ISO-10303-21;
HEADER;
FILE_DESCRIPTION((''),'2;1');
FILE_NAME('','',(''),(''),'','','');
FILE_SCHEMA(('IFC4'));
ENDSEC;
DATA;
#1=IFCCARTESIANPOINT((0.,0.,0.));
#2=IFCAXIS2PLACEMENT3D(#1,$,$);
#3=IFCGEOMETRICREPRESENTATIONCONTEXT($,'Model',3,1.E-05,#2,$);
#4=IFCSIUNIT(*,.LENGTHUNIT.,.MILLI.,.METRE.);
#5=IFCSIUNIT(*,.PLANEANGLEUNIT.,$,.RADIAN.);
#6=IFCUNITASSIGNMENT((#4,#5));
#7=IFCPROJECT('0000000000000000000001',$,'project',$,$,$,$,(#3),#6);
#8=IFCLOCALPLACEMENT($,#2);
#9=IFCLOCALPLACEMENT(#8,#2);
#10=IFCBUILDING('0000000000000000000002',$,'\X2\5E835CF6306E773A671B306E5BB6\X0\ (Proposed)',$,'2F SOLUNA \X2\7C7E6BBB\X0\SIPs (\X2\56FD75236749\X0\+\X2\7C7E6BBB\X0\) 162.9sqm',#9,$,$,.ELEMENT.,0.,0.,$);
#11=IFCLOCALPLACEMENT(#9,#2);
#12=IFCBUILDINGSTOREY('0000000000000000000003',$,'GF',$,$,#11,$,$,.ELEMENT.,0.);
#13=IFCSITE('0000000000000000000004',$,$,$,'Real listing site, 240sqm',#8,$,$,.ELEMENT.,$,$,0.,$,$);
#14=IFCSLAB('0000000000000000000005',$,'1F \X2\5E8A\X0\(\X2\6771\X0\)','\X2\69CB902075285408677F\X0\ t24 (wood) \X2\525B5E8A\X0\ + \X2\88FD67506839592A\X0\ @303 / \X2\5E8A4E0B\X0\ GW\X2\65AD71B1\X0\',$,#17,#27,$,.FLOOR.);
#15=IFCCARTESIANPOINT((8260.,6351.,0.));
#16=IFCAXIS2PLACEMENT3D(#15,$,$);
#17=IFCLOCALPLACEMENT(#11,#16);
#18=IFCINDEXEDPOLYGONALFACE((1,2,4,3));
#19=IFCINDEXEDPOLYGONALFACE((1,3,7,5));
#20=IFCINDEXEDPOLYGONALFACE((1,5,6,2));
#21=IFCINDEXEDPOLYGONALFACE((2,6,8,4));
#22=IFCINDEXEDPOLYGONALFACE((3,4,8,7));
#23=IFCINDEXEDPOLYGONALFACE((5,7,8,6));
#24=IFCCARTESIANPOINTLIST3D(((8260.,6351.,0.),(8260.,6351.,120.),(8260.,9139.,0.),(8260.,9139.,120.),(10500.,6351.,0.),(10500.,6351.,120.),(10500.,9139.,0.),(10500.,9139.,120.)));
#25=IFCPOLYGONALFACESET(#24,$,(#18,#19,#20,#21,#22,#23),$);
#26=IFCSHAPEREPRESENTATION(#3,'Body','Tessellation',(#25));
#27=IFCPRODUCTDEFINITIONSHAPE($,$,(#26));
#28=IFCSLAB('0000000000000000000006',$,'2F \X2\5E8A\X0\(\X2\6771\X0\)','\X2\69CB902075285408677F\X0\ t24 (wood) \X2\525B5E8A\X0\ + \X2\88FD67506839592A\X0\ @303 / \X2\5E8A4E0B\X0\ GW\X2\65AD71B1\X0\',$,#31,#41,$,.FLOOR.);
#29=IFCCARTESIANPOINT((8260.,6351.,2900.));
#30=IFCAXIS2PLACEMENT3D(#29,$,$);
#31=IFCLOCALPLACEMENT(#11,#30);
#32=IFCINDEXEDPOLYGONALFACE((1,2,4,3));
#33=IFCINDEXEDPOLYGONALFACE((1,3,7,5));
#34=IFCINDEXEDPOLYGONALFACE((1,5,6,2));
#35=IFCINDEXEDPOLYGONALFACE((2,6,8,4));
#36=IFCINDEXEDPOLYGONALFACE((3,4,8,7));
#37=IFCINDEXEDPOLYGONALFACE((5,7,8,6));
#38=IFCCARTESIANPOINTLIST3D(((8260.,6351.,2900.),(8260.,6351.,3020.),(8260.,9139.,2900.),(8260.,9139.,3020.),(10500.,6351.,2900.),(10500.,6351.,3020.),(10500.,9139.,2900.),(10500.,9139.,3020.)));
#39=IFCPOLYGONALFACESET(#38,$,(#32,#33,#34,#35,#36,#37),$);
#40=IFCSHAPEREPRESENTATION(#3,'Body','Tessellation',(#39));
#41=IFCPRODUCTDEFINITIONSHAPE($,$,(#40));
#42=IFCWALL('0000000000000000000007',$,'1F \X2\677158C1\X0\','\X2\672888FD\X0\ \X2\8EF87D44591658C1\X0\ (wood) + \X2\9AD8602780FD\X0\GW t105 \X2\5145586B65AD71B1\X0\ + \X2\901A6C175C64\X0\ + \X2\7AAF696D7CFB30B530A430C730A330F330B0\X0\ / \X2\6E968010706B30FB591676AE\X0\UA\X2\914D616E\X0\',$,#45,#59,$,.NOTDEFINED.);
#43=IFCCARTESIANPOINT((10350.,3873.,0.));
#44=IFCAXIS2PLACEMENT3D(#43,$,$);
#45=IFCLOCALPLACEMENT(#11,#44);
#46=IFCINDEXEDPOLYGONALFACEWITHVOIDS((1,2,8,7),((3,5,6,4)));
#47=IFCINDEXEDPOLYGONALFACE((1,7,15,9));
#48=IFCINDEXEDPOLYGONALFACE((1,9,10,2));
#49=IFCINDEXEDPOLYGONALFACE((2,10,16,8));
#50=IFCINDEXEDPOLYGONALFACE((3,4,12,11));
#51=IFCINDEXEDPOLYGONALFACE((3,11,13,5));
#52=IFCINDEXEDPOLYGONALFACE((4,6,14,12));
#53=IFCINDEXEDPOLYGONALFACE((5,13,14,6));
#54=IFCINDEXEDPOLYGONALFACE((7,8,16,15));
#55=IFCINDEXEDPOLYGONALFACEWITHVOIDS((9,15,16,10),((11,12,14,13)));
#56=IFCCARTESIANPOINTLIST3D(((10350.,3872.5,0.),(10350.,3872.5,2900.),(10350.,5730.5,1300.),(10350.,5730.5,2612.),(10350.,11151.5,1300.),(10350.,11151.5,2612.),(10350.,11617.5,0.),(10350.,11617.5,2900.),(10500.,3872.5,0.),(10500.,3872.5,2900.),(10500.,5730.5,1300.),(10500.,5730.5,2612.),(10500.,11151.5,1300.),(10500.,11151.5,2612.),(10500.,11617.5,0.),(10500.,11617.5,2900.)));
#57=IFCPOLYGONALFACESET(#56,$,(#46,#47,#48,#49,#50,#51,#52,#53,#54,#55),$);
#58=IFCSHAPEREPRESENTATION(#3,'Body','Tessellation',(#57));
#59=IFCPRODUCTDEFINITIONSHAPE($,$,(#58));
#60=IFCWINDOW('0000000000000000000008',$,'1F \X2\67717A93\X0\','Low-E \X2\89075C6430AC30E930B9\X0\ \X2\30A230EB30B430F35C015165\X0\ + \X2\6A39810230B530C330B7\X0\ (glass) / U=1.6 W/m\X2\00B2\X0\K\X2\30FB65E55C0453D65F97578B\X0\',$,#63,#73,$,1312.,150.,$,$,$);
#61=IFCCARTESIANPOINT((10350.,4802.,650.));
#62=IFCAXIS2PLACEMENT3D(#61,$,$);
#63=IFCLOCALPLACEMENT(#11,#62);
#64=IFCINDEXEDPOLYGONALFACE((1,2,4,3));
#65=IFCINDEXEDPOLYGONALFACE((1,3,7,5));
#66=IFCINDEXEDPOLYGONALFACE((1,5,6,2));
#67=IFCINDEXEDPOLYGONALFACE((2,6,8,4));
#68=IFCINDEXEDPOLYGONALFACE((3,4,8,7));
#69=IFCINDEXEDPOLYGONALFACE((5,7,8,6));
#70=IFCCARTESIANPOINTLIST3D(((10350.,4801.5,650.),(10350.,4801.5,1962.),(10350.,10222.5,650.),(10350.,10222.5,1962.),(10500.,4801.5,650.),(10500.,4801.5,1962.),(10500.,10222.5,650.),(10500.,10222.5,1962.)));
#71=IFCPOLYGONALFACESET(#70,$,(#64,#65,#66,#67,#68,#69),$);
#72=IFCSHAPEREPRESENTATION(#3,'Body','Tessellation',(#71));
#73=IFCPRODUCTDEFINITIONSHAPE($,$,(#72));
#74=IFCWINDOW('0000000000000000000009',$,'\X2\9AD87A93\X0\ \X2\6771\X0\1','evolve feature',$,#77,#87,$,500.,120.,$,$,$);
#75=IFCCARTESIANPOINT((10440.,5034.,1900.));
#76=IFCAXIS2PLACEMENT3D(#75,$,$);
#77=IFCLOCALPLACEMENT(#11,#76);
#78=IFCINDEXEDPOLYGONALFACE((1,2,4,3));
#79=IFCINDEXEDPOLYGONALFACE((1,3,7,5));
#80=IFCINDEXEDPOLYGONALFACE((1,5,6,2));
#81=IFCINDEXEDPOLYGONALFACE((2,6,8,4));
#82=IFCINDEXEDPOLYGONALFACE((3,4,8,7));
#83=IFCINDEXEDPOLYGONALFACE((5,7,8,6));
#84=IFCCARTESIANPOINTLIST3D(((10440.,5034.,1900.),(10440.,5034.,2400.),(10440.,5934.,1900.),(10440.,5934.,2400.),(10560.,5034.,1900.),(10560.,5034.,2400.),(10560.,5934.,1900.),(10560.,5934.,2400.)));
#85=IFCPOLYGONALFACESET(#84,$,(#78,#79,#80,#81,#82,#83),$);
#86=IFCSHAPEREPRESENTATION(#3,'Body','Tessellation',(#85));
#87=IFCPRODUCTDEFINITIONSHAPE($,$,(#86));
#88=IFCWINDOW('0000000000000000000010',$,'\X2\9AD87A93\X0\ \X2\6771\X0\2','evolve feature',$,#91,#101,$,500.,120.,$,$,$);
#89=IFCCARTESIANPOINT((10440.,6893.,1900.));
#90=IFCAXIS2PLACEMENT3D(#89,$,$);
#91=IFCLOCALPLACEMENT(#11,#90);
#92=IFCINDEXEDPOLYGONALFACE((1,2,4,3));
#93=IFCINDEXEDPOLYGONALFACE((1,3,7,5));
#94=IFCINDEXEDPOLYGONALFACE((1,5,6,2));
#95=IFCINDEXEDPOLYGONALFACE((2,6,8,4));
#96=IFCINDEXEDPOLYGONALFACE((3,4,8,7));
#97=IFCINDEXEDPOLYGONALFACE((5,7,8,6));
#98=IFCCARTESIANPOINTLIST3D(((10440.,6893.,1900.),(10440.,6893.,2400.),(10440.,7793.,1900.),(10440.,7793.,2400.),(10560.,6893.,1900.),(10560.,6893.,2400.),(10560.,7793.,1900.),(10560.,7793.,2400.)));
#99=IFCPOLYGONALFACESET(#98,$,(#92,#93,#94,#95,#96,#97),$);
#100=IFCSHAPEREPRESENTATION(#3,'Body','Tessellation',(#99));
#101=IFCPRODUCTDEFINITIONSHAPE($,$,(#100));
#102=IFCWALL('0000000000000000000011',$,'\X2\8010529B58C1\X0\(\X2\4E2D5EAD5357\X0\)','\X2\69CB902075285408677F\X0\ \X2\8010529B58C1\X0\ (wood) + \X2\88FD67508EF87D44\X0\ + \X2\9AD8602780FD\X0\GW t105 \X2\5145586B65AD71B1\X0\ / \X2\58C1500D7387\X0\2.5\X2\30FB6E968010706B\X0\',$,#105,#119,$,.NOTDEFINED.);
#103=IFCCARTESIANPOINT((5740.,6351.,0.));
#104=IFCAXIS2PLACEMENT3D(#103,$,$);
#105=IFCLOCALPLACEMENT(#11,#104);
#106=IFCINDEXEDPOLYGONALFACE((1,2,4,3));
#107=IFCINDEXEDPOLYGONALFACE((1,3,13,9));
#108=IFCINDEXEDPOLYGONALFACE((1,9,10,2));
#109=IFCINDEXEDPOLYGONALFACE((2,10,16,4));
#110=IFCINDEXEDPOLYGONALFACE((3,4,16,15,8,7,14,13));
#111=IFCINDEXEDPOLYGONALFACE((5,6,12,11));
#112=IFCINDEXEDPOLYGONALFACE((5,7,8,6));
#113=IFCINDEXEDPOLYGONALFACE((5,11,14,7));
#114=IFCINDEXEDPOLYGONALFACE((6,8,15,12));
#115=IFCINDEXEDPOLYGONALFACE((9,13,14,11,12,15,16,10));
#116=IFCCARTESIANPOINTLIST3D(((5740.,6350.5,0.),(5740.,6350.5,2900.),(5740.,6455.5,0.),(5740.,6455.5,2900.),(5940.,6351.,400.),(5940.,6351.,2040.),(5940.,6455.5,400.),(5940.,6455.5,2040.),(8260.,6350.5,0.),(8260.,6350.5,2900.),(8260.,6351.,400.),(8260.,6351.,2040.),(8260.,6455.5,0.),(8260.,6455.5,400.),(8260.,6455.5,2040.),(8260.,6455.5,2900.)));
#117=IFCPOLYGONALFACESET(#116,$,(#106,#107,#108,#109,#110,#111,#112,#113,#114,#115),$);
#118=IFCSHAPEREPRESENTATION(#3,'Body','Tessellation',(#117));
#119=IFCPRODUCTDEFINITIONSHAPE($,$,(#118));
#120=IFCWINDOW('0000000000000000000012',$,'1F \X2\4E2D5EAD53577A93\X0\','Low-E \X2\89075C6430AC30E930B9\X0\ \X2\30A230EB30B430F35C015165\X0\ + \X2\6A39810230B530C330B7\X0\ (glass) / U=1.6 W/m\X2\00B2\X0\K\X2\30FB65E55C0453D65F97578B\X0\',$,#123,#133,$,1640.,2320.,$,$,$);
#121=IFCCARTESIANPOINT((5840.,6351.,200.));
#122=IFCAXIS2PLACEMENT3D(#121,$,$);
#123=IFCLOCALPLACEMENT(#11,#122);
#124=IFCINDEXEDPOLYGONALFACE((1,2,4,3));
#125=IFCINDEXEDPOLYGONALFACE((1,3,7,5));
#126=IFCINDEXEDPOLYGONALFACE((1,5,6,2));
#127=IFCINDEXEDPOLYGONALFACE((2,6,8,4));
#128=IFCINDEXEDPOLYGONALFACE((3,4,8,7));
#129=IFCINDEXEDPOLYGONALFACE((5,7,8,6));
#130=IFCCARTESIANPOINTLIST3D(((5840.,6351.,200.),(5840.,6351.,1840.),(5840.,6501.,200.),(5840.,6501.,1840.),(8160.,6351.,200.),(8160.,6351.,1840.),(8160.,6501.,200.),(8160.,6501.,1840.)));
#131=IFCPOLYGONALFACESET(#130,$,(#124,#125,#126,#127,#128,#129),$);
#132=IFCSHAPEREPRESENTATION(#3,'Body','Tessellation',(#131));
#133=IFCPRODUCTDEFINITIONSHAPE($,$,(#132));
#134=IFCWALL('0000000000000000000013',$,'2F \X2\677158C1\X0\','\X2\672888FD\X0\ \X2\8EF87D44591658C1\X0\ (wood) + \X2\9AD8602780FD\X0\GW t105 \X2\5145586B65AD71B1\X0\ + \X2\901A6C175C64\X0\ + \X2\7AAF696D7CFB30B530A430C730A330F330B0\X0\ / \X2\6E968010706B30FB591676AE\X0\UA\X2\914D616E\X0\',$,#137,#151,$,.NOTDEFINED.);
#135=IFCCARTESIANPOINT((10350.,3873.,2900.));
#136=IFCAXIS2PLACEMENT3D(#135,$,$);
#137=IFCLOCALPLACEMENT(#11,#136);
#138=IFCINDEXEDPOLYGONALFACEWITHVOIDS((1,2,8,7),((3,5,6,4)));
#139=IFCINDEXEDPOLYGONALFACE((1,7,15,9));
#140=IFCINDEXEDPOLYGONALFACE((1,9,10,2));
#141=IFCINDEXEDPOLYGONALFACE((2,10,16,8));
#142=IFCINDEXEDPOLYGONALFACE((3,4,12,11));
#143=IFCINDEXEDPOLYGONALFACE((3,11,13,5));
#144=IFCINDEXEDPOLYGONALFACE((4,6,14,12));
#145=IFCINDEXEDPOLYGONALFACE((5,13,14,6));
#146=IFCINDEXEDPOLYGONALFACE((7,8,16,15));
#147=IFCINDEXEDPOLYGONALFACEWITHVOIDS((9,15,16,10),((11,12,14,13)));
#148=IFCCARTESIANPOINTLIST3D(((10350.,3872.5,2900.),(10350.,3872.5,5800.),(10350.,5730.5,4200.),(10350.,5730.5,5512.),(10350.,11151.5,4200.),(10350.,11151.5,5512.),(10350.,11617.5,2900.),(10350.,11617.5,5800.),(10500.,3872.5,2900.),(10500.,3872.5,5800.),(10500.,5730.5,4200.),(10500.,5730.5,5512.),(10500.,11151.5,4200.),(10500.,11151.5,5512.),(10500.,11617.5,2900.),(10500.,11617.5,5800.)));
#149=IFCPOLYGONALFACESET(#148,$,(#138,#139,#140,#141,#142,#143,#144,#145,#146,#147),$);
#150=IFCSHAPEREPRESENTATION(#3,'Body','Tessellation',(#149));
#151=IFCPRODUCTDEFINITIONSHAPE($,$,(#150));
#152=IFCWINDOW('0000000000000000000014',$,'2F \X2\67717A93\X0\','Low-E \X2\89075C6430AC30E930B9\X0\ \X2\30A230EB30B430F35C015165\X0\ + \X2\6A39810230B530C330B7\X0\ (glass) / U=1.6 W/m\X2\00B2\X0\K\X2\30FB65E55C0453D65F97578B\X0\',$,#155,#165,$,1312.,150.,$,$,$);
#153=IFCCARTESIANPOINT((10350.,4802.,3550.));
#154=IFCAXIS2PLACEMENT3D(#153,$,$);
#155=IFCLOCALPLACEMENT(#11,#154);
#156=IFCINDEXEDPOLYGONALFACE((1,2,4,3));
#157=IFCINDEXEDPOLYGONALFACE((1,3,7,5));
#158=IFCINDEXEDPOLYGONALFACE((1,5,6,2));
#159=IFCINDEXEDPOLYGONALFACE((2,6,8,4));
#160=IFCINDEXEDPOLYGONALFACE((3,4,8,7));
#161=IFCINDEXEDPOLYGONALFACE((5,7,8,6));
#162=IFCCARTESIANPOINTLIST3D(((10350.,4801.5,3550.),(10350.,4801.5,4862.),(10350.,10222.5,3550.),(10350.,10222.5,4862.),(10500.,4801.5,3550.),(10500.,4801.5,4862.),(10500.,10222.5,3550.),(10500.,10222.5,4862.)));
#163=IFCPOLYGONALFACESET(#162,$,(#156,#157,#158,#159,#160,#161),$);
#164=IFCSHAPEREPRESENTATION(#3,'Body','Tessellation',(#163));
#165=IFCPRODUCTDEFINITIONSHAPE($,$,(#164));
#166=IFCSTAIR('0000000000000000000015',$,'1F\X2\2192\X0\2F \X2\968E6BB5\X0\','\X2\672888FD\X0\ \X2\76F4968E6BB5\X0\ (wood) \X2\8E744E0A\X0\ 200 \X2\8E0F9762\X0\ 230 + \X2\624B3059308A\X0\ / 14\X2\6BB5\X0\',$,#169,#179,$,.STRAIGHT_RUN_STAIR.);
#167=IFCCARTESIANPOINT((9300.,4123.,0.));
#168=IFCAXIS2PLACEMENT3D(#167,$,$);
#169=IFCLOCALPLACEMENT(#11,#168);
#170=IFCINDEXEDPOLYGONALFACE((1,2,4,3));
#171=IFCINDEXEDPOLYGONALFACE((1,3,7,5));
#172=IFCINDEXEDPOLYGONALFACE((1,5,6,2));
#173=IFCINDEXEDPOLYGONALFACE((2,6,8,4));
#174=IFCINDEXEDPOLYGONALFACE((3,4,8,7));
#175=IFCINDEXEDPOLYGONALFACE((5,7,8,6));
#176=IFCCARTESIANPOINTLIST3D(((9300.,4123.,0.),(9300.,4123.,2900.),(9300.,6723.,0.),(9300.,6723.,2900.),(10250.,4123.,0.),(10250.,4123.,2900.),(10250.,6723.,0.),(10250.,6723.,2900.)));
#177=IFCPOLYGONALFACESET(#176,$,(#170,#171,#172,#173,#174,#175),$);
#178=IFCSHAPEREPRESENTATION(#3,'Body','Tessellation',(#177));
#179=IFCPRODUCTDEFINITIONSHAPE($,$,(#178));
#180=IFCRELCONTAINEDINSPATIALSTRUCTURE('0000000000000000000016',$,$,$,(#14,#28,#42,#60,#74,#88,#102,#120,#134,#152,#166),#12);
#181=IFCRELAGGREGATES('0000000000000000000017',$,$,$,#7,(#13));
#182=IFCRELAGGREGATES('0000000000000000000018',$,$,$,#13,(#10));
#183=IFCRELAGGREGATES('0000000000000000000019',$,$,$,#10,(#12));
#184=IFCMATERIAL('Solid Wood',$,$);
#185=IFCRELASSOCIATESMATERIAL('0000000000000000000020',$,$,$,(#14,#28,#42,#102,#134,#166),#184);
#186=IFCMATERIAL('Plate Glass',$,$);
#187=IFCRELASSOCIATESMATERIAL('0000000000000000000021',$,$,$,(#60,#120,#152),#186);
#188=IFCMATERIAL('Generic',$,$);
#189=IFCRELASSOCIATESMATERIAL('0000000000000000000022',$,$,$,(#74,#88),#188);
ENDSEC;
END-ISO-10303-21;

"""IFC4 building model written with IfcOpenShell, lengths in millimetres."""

from ifc_helpers import new_model, si_unit, frame, frame_2d, origin, place, context, project, spatial, rectangle, extrude, material, element, fill, save


model = new_model("IFC4")

# Units and contexts
model_context = context("Model", 3, precision=1e-05, world=origin())
ifc_project = project(units=[si_unit("LENGTHUNIT", "METRE", prefix="MILLI"), si_unit("PLANEANGLEUNIT", "RADIAN")], contexts=[model_context])

# Site, building, storey
site_placement = place(None, origin())
site = spatial("IfcSite", under=ifc_project, at=site_placement, ObjectType="Real listing site, 240sqm", CompositionType="ELEMENT", RefElevation=0.0)
building_placement = place(site_placement, origin())
building = spatial("IfcBuilding", under=site, at=building_placement, Name="広島の眺望の家 (Proposed)", ObjectType="2F SOLUNA 籾殻SIPs (国産杉+籾殻) 162.9sqm", CompositionType="ELEMENT", ElevationOfRefHeight=0.0, ElevationOfTerrain=0.0)
storey_placement = place(building_placement, origin())
storey = spatial("IfcBuildingStorey", under=building, at=storey_placement, Name="GF", CompositionType="ELEMENT", Elevation=0.0)

# Slabs
ifc_material_1 = material(Name="Solid Wood")
slab_1_placement = place(storey_placement, frame((8260.0, 6351.0, 0.0)))
element("IfcSlab", 1, at=slab_1_placement, inside=storey, material=ifc_material_1, Name="1F 床(東)", Description="構造用合板 t24 (wood) 剛床 + 製材根太 @303 / 床下 GW断熱", PredefinedType="FLOOR", context=model_context, shape_type="SweptSolid", body=[
    extrude(rectangle(XDim=2240.0, YDim=2788.0, at=frame_2d((1120.0, 1394.0))), frame((8260.0, 6351.0, 0.0)), (0.0, 0.0, 1.0), 120.0),
])
slab_2_placement = place(storey_placement, frame((8260.0, 6351.0, 2900.0)))
element("IfcSlab", 2, at=slab_2_placement, inside=storey, material=ifc_material_1, Name="2F 床(東)", Description="構造用合板 t24 (wood) 剛床 + 製材根太 @303 / 床下 GW断熱", PredefinedType="FLOOR", context=model_context, shape_type="SweptSolid", body=[
    extrude(rectangle(XDim=2240.0, YDim=2788.0, at=frame_2d((1120.0, 1394.0))), frame((8260.0, 6351.0, 2900.0)), (0.0, 0.0, 1.0), 120.0),
])

# Wall, openings, windows
wall_1_placement = place(storey_placement, frame((10350.0, 3873.0, 0.0)))
wall_1 = element("IfcWall", 3, at=wall_1_placement, inside=storey, material=ifc_material_1, Name="1F 東壁", Description="木製 軸組外壁 (wood) + 高性能GW t105 充填断熱 + 通気層 + 窯業系サイディング / 準耐火・外皮UA配慮", PredefinedType="NOTDEFINED", context=model_context, shape_type="SweptSolid", body=[
    extrude(rectangle(XDim=150.0, YDim=7745.0, at=frame_2d((75.0, 3872.0))), frame((10350.0, 3873.0, 0.0)), (0.0, 0.0, 1.0), 2900.0),
])
opening_1_placement = place(storey_placement, frame((10350.0, 4802.0, 650.0)))
opening_1 = element("IfcOpeningElement", 4, at=opening_1_placement, cuts=wall_1, PredefinedType="NOTDEFINED", context=model_context, shape_type="SweptSolid", body=[
    extrude(rectangle(XDim=150.0, YDim=5421.0, at=frame_2d((75.0, 2710.0))), frame((10350.0, 4802.0, 650.0)), (0.0, 0.0, 1.0), 1312.0),
])
opening_2_placement = place(storey_placement, frame((10440.0, 5034.0, 1900.0)))
opening_2 = element("IfcOpeningElement", 5, at=opening_2_placement, cuts=wall_1, PredefinedType="NOTDEFINED", context=model_context, shape_type="SweptSolid", body=[
    extrude(rectangle(XDim=120.0, YDim=900.0, at=frame_2d((60.0, 450.0))), frame((10440.0, 5034.0, 1900.0)), (0.0, 0.0, 1.0), 500.0),
])
opening_3_placement = place(storey_placement, frame((10440.0, 6893.0, 1900.0)))
opening_3 = element("IfcOpeningElement", 6, at=opening_3_placement, cuts=wall_1, PredefinedType="NOTDEFINED", context=model_context, shape_type="SweptSolid", body=[
    extrude(rectangle(XDim=120.0, YDim=900.0, at=frame_2d((60.0, 450.0))), frame((10440.0, 6893.0, 1900.0)), (0.0, 0.0, 1.0), 500.0),
])
ifc_material_2 = material(Name="Plate Glass")
window_1_placement = place(storey_placement, frame((10350.0, 4802.0, 650.0)))
window_1 = element("IfcWindow", 7, at=window_1_placement, inside=storey, material=ifc_material_2, Name="1F 東窓", Description="Low-E 複層ガラス アルゴン封入 + 樹脂サッシ (glass) / U=1.6 W/m²K・日射取得型", OverallHeight=1312.0, OverallWidth=150.0, context=model_context, shape_type="SweptSolid", body=[
    extrude(rectangle(XDim=150.0, YDim=5421.0, at=frame_2d((75.0, 2710.0))), frame((10350.0, 4802.0, 650.0)), (0.0, 0.0, 1.0), 1312.0),
])
fill(opening_1, window_1)
ifc_material_3 = material(Name="Generic")
window_2_placement = place(storey_placement, frame((10440.0, 5034.0, 1900.0)))
window_2 = element("IfcWindow", 8, at=window_2_placement, inside=storey, material=ifc_material_3, Name="高窓 東1", Description="evolve feature", OverallHeight=500.0, OverallWidth=120.0, context=model_context, shape_type="SweptSolid", body=[
    extrude(rectangle(XDim=120.0, YDim=900.0, at=frame_2d((60.0, 450.0))), frame((10440.0, 5034.0, 1900.0)), (0.0, 0.0, 1.0), 500.0),
])
fill(opening_2, window_2)
window_3_placement = place(storey_placement, frame((10440.0, 6893.0, 1900.0)))
window_3 = element("IfcWindow", 9, at=window_3_placement, inside=storey, material=ifc_material_3, Name="高窓 東2", Description="evolve feature", OverallHeight=500.0, OverallWidth=120.0, context=model_context, shape_type="SweptSolid", body=[
    extrude(rectangle(XDim=120.0, YDim=900.0, at=frame_2d((60.0, 450.0))), frame((10440.0, 6893.0, 1900.0)), (0.0, 0.0, 1.0), 500.0),
])
fill(opening_3, window_3)

# Wall, opening, window
wall_2_placement = place(storey_placement, frame((5740.0, 6351.0, 0.0)))
wall_2 = element("IfcWall", 10, at=wall_2_placement, inside=storey, material=ifc_material_1, Name="耐力壁(中庭南)", Description="構造用合板 耐力壁 (wood) + 製材軸組 + 高性能GW t105 充填断熱 / 壁倍率2.5・準耐火", PredefinedType="NOTDEFINED", context=model_context, shape_type="SweptSolid", body=[
    extrude(rectangle(XDim=2520.0, YDim=105.0, at=frame_2d((1260.0, 52.0))), frame((5740.0, 6351.0, 0.0)), (0.0, 0.0, 1.0), 2900.0),
])
opening_4_placement = place(storey_placement, frame((5840.0, 6351.0, 200.0)))
opening_4 = element("IfcOpeningElement", 11, at=opening_4_placement, cuts=wall_2, PredefinedType="NOTDEFINED", context=model_context, shape_type="SweptSolid", body=[
    extrude(rectangle(XDim=2320.0, YDim=150.0, at=frame_2d((1160.0, 75.0))), frame((5840.0, 6351.0, 200.0)), (0.0, 0.0, 1.0), 1640.0),
])
window_4_placement = place(storey_placement, frame((5840.0, 6351.0, 200.0)))
window_4 = element("IfcWindow", 12, at=window_4_placement, inside=storey, material=ifc_material_2, Name="1F 中庭南窓", Description="Low-E 複層ガラス アルゴン封入 + 樹脂サッシ (glass) / U=1.6 W/m²K・日射取得型", OverallHeight=1640.0, OverallWidth=2320.0, context=model_context, shape_type="SweptSolid", body=[
    extrude(rectangle(XDim=2320.0, YDim=150.0, at=frame_2d((1160.0, 75.0))), frame((5840.0, 6351.0, 200.0)), (0.0, 0.0, 1.0), 1640.0),
])
fill(opening_4, window_4)

# Wall, opening, window
wall_3_placement = place(storey_placement, frame((10350.0, 3873.0, 2900.0)))
wall_3 = element("IfcWall", 13, at=wall_3_placement, inside=storey, material=ifc_material_1, Name="2F 東壁", Description="木製 軸組外壁 (wood) + 高性能GW t105 充填断熱 + 通気層 + 窯業系サイディング / 準耐火・外皮UA配慮", PredefinedType="NOTDEFINED", context=model_context, shape_type="SweptSolid", body=[
    extrude(rectangle(XDim=150.0, YDim=7745.0, at=frame_2d((75.0, 3872.0))), frame((10350.0, 3873.0, 2900.0)), (0.0, 0.0, 1.0), 2900.0),
])
opening_5_placement = place(storey_placement, frame((10350.0, 4802.0, 3550.0)))
opening_5 = element("IfcOpeningElement", 14, at=opening_5_placement, cuts=wall_3, PredefinedType="NOTDEFINED", context=model_context, shape_type="SweptSolid", body=[
    extrude(rectangle(XDim=150.0, YDim=5421.0, at=frame_2d((75.0, 2710.0))), frame((10350.0, 4802.0, 3550.0)), (0.0, 0.0, 1.0), 1312.0),
])
window_5_placement = place(storey_placement, frame((10350.0, 4802.0, 3550.0)))
window_5 = element("IfcWindow", 15, at=window_5_placement, inside=storey, material=ifc_material_2, Name="2F 東窓", Description="Low-E 複層ガラス アルゴン封入 + 樹脂サッシ (glass) / U=1.6 W/m²K・日射取得型", OverallHeight=1312.0, OverallWidth=150.0, context=model_context, shape_type="SweptSolid", body=[
    extrude(rectangle(XDim=150.0, YDim=5421.0, at=frame_2d((75.0, 2710.0))), frame((10350.0, 4802.0, 3550.0)), (0.0, 0.0, 1.0), 1312.0),
])
fill(opening_5, window_5)

# Stair
stair_placement = place(storey_placement, frame((9300.0, 4123.0, 0.0)))
element("IfcStair", 16, at=stair_placement, inside=storey, material=ifc_material_1, Name="1F→2F 階段", Description="木製 直階段 (wood) 蹴上 200 踏面 230 + 手すり / 14段", PredefinedType="STRAIGHT_RUN_STAIR", context=model_context, shape_type="SweptSolid", body=[
    extrude(rectangle(XDim=950.0, YDim=2600.0, at=frame_2d((475.0, 1300.0))), frame((9300.0, 4123.0, 0.0)), (0.0, 0.0, 1.0), 2900.0),
])

save(model, "model.ifc")
